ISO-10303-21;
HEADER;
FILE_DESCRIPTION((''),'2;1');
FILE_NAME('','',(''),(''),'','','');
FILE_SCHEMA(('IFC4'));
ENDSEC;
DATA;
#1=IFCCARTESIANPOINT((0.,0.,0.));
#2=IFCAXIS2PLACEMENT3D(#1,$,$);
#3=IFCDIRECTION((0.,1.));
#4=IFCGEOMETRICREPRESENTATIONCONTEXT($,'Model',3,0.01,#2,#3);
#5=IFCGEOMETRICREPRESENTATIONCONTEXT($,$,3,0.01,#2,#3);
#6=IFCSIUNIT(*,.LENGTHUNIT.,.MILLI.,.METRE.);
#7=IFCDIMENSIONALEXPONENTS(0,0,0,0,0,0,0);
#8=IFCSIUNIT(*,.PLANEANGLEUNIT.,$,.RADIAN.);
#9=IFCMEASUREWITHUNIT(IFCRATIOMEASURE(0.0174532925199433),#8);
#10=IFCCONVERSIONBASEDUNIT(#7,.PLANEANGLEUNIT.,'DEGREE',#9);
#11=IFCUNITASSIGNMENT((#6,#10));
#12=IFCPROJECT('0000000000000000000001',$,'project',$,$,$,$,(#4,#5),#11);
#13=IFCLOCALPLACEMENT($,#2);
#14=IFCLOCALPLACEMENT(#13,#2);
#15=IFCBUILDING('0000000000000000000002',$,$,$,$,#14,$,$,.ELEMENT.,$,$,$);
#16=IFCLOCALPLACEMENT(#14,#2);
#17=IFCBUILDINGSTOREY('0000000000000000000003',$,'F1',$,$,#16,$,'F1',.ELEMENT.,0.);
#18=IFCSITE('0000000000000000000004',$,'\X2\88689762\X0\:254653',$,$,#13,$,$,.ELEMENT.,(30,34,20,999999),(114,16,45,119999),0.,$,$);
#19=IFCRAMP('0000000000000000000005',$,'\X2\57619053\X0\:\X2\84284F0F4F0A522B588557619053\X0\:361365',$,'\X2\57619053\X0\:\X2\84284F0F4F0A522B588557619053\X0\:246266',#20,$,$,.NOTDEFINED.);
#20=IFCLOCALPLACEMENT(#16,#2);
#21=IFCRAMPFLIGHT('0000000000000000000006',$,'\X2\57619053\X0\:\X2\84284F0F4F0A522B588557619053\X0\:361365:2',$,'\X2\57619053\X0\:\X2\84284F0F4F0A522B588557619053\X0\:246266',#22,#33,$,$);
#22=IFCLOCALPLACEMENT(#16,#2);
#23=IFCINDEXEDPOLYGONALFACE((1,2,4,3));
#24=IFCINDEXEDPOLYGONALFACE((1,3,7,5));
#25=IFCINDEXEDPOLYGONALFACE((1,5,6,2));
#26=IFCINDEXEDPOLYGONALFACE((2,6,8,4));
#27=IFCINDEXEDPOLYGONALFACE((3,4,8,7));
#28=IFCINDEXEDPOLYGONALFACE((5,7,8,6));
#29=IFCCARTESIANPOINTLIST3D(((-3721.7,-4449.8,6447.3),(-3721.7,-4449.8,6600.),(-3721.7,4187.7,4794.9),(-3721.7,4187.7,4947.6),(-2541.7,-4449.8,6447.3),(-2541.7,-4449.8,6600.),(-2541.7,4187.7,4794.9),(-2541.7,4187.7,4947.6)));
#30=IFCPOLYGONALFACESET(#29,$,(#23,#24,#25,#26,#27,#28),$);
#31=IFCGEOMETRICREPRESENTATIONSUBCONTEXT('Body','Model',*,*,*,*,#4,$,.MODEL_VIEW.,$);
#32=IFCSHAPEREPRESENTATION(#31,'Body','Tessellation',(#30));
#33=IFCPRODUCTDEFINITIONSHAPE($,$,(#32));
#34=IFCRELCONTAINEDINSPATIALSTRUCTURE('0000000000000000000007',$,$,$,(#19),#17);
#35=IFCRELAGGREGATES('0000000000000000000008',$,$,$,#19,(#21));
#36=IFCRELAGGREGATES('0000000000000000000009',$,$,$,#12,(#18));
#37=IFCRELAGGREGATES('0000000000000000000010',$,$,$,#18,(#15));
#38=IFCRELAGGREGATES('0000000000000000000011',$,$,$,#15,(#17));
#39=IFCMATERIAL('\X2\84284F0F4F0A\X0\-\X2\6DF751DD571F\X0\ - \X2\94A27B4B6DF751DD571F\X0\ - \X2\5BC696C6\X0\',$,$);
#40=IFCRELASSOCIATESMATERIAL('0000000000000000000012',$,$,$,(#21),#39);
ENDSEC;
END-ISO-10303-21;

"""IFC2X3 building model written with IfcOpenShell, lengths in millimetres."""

from ifc_helpers import new_model, entity, si_unit, converted_unit, direction, frame, origin, place, context, subcontext, project, spatial, polyline, outline, extrude, material, element, aggregate, save


model = new_model("IFC2X3")

# Units and contexts
model_context = context("Model", 3, precision=0.01, world=origin(), true_north=direction((0.0, 1.0)))
context_of_model = context(None, 3, precision=0.01, world=origin(), true_north=direction((0.0, 1.0)))
body_context = subcontext(model_context, "Body", "Model", "MODEL_VIEW")
ifc_project = project(units=[si_unit("LENGTHUNIT", "METRE", prefix="MILLI"), converted_unit("PLANEANGLEUNIT", "DEGREE", entity("IfcRatioMeasure", 0.0174532925199433), si_unit("PLANEANGLEUNIT", "RADIAN"), dimensions=[0, 0, 0, 0, 0, 0, 0])], contexts=[model_context, context_of_model])

# Site, building, storey
site_placement = place(None, origin())
site = spatial("IfcSite", under=ifc_project, at=site_placement, Name="表面:254653", CompositionType="ELEMENT", RefLatitude=(30, 34, 20, 999999), RefLongitude=(114, 16, 45, 119999), RefElevation=0.0)
building_placement = place(site_placement, origin())
building = spatial("IfcBuilding", under=site, at=building_placement, CompositionType="ELEMENT")
storey_placement = place(building_placement, origin())
storey = spatial("IfcBuildingStorey", under=building, at=storey_placement, Name="F1", LongName="F1", CompositionType="ELEMENT", Elevation=0.0)

# Ramp
ramp_placement = place(storey_placement, origin())
ramp = element("IfcRamp", 1, at=ramp_placement, inside=storey, Name="坡道:萨伏伊别墅坡道:361365", ObjectType="坡道:萨伏伊别墅坡道:246266", ShapeType="NOTDEFINED")
ifc_material_1 = material(Name="萨伏伊-混凝土 - 钢筋混凝土 - 密集")

# Ramp flight
ramp_flight_1_placement = place(ramp_placement, origin())
ramp_flight_1 = element("IfcRampFlight", 2, at=ramp_flight_1_placement, material=ifc_material_1, Name="坡道:萨伏伊别墅坡道:361365:2", ObjectType="坡道:萨伏伊别墅坡道:246266", context=body_context, shape_type="SweptSolid", body=[
    extrude(outline(polyline([(-902.6, -4318.7), (-749.8, -4318.7), (902.6, 4318.7), (749.8, 4318.7), (-902.6, -4318.7)])), frame((-3721.7, -131.1, 5697.4), z_axis=(1.0, 0.0, 0.0), x_axis=(0.0, 0.0, -1.0)), (0.0, 0.0, 1.0), 1180.0),
])
aggregate(ramp, [ramp_flight_1])

save(model, "model.ifc")
